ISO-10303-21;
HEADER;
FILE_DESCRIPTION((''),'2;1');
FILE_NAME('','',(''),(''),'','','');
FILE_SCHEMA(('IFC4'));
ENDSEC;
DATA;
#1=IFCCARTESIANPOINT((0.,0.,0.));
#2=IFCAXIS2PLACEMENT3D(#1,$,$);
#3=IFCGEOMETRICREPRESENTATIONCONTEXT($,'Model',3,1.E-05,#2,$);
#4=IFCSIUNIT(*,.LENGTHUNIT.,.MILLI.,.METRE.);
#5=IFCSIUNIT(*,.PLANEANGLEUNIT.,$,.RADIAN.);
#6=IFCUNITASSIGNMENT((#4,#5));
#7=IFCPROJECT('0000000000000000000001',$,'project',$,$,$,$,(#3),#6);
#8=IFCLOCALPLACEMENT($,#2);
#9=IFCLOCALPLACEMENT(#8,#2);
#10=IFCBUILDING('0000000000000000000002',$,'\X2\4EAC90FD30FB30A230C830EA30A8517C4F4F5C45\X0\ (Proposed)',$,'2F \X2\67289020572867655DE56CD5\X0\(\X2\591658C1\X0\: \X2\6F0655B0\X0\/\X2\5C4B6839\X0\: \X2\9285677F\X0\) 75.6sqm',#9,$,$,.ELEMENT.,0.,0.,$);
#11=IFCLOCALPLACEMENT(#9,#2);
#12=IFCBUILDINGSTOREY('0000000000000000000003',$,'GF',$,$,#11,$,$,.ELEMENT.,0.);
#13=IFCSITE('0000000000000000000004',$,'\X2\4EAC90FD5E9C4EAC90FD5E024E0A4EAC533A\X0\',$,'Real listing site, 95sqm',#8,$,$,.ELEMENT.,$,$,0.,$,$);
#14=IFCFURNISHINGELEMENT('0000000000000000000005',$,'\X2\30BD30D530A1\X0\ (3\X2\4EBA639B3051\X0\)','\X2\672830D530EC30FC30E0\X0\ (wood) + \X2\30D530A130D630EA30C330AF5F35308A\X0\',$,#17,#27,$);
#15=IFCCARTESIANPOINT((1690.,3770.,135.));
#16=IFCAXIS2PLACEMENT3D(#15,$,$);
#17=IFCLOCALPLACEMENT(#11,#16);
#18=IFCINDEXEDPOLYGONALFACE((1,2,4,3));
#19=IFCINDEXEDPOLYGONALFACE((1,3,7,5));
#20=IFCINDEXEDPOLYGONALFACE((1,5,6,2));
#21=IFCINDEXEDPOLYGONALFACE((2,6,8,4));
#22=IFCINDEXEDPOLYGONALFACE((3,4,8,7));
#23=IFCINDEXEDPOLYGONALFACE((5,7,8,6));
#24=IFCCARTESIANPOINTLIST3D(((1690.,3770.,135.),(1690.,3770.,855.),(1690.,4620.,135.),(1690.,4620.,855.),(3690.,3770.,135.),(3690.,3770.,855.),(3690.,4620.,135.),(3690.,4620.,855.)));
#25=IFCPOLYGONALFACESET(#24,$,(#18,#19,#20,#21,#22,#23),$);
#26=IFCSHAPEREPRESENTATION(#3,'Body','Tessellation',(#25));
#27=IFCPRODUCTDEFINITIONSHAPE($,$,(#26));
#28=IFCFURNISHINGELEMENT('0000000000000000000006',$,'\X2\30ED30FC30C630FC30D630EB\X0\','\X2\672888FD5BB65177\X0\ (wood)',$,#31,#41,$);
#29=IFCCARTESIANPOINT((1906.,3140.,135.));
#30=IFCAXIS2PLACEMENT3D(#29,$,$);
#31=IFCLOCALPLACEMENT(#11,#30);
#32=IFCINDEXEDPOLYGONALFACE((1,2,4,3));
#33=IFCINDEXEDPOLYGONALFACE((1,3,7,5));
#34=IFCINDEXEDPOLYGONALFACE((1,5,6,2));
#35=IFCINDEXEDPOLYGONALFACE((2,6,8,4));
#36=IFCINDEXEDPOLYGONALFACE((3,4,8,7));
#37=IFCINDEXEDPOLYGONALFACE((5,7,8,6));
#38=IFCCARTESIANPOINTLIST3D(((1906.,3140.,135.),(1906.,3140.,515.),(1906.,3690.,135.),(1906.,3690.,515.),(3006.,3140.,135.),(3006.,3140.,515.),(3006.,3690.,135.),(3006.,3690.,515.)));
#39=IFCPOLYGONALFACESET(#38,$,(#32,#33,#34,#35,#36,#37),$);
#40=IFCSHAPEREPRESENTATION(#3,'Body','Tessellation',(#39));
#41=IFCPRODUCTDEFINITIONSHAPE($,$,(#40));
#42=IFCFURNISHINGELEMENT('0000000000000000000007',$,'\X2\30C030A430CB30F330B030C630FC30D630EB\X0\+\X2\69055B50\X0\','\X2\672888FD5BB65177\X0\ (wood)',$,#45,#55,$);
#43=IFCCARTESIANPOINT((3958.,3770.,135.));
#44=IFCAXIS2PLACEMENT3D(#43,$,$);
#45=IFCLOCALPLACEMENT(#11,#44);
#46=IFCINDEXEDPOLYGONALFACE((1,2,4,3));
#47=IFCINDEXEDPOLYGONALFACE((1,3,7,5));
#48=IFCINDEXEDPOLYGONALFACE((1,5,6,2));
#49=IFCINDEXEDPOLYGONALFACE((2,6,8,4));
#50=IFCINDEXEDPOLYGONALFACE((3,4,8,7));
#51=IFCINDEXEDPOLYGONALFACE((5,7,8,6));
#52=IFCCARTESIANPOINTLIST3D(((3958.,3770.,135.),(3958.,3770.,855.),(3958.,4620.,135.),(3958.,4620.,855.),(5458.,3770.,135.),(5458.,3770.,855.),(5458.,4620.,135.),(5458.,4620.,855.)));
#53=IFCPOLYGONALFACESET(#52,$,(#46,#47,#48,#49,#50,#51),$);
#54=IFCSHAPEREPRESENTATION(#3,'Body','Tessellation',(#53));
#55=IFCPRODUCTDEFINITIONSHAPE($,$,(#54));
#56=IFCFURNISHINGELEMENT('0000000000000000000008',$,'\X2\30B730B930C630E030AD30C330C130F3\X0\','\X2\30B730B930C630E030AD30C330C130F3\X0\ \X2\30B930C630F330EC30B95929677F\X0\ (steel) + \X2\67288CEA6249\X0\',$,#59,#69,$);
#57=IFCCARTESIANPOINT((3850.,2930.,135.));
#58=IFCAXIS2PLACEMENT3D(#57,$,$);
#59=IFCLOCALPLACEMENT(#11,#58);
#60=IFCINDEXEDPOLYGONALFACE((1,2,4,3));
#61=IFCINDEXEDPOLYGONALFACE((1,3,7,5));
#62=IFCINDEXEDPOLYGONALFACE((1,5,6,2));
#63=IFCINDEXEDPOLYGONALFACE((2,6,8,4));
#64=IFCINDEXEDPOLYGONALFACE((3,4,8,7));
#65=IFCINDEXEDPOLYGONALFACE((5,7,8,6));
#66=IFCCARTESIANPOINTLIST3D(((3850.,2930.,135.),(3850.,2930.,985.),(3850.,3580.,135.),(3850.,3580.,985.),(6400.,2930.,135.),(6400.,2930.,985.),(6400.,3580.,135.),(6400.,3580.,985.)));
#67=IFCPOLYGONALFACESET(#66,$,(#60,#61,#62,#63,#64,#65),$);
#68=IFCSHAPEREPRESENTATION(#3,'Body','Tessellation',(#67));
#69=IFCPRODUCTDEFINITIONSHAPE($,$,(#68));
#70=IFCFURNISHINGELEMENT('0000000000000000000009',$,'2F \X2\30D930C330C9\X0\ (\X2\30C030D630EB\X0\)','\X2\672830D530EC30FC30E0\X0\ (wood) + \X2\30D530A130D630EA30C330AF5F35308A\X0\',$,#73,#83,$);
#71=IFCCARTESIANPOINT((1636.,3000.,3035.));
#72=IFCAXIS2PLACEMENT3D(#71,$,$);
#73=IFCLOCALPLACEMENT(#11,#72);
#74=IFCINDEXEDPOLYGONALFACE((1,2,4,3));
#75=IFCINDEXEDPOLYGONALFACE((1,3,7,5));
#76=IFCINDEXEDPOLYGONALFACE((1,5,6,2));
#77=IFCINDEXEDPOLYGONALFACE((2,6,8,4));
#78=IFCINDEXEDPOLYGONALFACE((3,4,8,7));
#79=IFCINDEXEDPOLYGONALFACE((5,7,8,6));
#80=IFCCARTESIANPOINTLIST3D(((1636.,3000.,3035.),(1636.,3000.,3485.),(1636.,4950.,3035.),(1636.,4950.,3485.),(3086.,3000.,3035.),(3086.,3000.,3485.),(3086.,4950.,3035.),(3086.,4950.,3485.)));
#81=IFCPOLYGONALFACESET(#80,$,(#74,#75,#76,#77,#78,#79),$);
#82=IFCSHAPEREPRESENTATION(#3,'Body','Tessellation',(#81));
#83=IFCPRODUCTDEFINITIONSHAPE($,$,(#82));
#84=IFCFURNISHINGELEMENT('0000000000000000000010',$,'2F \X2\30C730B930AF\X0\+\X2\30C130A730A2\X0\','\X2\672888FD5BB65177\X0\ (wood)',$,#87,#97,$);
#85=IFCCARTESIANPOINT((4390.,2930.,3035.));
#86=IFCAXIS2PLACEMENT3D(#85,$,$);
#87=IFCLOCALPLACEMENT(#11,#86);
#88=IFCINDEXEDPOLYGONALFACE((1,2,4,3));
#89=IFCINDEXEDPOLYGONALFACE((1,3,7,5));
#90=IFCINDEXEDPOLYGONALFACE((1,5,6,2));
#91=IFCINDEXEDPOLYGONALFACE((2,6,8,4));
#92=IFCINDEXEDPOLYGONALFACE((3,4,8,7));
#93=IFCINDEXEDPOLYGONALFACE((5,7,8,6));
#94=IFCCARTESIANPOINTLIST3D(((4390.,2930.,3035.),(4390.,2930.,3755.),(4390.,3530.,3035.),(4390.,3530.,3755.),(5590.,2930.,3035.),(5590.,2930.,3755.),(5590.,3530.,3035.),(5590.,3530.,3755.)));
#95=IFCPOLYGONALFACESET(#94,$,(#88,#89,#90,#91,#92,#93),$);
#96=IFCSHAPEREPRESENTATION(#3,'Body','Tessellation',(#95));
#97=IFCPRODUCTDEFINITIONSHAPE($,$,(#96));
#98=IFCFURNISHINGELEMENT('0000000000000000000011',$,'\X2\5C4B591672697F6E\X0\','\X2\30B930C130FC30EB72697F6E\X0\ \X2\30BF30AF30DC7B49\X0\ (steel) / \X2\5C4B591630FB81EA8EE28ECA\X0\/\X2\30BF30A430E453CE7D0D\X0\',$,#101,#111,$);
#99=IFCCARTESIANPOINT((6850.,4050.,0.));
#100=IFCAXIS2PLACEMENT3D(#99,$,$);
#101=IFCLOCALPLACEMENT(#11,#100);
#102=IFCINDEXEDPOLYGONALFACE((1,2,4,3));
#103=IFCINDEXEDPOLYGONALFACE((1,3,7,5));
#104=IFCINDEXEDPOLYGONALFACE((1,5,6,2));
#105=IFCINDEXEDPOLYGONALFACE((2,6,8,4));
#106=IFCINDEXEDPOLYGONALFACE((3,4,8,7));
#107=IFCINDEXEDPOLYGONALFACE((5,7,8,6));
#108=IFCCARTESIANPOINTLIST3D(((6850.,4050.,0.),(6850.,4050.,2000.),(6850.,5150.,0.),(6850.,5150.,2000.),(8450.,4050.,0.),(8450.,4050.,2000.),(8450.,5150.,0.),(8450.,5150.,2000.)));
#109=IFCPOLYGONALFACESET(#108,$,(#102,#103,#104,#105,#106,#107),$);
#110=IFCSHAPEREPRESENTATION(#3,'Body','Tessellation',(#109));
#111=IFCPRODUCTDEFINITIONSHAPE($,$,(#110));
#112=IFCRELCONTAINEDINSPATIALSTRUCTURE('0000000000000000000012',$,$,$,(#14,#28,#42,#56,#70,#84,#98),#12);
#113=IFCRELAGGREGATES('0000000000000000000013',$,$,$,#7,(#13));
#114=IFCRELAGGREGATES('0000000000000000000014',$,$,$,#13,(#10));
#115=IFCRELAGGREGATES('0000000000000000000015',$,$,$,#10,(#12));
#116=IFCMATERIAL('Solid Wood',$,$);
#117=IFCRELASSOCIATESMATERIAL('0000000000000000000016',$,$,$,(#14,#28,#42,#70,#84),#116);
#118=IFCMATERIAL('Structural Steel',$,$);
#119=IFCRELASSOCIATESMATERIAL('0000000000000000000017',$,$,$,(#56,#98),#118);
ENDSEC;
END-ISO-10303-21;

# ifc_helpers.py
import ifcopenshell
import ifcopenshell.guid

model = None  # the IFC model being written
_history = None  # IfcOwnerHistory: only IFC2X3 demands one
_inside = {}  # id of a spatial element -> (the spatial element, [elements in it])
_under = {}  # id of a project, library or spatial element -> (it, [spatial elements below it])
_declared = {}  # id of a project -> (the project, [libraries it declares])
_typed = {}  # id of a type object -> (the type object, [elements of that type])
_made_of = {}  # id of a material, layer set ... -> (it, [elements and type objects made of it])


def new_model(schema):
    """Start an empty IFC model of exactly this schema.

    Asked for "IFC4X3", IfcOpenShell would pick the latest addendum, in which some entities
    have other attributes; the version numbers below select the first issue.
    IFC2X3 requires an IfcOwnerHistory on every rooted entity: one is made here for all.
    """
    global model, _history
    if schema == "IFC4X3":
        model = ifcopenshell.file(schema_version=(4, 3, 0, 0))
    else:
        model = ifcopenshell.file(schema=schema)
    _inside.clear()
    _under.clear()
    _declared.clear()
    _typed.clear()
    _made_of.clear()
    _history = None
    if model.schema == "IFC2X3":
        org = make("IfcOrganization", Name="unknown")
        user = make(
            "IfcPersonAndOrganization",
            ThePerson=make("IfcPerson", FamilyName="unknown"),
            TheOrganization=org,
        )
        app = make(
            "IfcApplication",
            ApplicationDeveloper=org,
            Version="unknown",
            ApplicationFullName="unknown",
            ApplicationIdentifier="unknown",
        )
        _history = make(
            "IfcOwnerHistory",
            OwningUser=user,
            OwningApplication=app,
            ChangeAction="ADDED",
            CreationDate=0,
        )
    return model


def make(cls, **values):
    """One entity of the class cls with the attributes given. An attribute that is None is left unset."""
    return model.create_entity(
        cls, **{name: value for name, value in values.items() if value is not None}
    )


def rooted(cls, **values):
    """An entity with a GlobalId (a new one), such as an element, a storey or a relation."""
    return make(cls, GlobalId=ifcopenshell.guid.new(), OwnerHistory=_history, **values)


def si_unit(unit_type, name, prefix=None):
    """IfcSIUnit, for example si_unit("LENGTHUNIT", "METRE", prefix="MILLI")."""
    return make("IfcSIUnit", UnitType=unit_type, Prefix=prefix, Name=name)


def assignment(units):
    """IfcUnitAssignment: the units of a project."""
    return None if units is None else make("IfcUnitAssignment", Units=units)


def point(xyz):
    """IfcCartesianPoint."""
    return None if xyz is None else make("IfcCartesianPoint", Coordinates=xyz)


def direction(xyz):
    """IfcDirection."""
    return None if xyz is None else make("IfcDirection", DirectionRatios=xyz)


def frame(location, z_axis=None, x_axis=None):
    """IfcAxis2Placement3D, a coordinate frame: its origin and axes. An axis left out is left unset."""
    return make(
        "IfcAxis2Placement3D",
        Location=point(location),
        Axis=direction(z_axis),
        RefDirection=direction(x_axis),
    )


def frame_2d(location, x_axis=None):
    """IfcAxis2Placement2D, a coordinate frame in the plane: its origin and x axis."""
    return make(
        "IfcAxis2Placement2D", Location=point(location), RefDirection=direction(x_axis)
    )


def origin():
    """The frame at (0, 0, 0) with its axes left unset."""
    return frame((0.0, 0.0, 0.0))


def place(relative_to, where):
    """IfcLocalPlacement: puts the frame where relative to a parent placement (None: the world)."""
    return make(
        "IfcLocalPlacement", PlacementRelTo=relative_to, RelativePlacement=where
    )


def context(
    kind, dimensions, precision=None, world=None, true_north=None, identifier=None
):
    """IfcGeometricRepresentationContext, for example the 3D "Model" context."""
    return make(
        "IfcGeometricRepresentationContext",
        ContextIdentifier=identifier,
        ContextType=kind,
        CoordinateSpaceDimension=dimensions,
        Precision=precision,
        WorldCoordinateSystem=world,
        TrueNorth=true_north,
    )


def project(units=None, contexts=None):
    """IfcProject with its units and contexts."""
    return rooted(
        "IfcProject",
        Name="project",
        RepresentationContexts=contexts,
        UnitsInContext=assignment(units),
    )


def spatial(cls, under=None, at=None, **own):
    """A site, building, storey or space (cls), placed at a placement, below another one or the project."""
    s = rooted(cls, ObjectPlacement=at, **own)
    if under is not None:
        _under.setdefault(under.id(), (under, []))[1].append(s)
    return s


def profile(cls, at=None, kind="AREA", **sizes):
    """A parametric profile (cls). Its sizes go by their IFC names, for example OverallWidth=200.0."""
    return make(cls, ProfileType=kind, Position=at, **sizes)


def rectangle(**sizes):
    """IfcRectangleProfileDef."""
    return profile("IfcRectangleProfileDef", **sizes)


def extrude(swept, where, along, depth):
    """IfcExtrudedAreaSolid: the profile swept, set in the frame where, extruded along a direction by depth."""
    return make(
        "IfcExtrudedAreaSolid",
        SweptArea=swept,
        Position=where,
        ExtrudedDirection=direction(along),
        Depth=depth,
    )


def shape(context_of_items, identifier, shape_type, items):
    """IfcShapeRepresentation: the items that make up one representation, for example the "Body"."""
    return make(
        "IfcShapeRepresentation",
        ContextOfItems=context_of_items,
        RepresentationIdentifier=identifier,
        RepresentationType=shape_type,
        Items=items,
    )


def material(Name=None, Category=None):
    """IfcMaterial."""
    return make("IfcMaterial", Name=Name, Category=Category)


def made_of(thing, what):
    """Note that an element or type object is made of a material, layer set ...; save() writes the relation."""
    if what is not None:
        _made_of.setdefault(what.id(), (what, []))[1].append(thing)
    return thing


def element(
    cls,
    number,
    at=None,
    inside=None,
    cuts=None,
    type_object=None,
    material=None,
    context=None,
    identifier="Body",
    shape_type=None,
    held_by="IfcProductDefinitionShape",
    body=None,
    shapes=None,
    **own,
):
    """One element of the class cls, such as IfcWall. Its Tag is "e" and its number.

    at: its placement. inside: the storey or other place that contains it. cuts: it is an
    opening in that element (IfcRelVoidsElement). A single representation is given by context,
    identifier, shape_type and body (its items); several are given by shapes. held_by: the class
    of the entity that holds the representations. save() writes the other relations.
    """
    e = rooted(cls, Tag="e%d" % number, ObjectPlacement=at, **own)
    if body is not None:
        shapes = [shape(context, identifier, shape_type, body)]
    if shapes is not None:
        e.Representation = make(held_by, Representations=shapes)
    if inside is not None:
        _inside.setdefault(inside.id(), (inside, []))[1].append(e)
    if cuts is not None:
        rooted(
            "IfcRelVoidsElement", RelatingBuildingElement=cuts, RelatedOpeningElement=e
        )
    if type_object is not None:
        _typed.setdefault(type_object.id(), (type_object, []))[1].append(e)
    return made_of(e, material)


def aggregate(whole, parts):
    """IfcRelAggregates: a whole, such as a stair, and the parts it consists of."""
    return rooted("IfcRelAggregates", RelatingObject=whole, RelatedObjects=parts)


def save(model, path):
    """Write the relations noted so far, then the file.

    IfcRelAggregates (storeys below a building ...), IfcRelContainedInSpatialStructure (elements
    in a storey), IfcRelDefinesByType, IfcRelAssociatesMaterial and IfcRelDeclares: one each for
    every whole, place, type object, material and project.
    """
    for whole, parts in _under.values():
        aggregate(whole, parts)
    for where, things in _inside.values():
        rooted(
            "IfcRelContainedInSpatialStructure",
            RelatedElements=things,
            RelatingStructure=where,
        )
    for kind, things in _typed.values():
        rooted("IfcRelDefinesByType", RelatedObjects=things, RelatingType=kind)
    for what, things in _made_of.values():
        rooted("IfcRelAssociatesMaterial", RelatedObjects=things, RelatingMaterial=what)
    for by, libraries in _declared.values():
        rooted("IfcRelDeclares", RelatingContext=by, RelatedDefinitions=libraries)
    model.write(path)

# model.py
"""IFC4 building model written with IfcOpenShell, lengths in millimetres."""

from ifc_helpers import new_model, si_unit, frame, frame_2d, origin, place, context, project, spatial, rectangle, extrude, material, element, save


model = new_model("IFC4")

# Units and contexts
model_context = context("Model", 3, precision=1e-05, world=origin())
ifc_project = project(units=[si_unit("LENGTHUNIT", "METRE", prefix="MILLI"), si_unit("PLANEANGLEUNIT", "RADIAN")], contexts=[model_context])

# Site, building, storey
site_placement = place(None, origin())
site = spatial("IfcSite", under=ifc_project, at=site_placement, Name="京都府京都市上京区", ObjectType="Real listing site, 95sqm", CompositionType="ELEMENT", RefElevation=0.0)
building_placement = place(site_placement, origin())
building = spatial("IfcBuilding", under=site, at=building_placement, Name="京都・アトリエ兼住居 (Proposed)", ObjectType="2F 木造在来工法(外壁: 漆喰/屋根: 銅板) 75.6sqm", CompositionType="ELEMENT", ElevationOfRefHeight=0.0, ElevationOfTerrain=0.0)
storey_placement = place(building_placement, origin())
storey = spatial("IfcBuildingStorey", under=building, at=storey_placement, Name="GF", CompositionType="ELEMENT", Elevation=0.0)

# Shared definitions
ifc_material_1 = material(Name="Solid Wood")

# Shared definitions
ifc_material_2 = material(Name="Structural Steel")

# Furnishing elements
furnishing_1_placement = place(storey_placement, frame((1690.0, 3770.0, 135.0)))
element("IfcFurnishingElement", 1, at=furnishing_1_placement, inside=storey, material=ifc_material_1, Name="ソファ (3人掛け)", Description="木フレーム (wood) + ファブリック張り", context=model_context, shape_type="SweptSolid", body=[
    extrude(rectangle(XDim=2000.0, YDim=850.0, at=frame_2d((1000.0, 425.0))), frame((1690.0, 3770.0, 135.0)), (0.0, 0.0, 1.0), 720.0),
])
furnishing_2_placement = place(storey_placement, frame((1906.0, 3140.0, 135.0)))
element("IfcFurnishingElement", 2, at=furnishing_2_placement, inside=storey, material=ifc_material_1, Name="ローテーブル", Description="木製家具 (wood)", context=model_context, shape_type="SweptSolid", body=[
    extrude(rectangle(XDim=1100.0, YDim=550.0, at=frame_2d((550.0, 275.0))), frame((1906.0, 3140.0, 135.0)), (0.0, 0.0, 1.0), 380.0),
])
furnishing_3_placement = place(storey_placement, frame((3958.0, 3770.0, 135.0)))
element("IfcFurnishingElement", 3, at=furnishing_3_placement, inside=storey, material=ifc_material_1, Name="ダイニングテーブル+椅子", Description="木製家具 (wood)", context=model_context, shape_type="SweptSolid", body=[
    extrude(rectangle(XDim=1500.0, YDim=850.0, at=frame_2d((750.0, 425.0))), frame((3958.0, 3770.0, 135.0)), (0.0, 0.0, 1.0), 720.0),
])
furnishing_4_placement = place(storey_placement, frame((3850.0, 2930.0, 135.0)))
element("IfcFurnishingElement", 4, at=furnishing_4_placement, inside=storey, material=ifc_material_2, Name="システムキッチン", Description="システムキッチン ステンレス天板 (steel) + 木質扉", context=model_context, shape_type="SweptSolid", body=[
    extrude(rectangle(XDim=2550.0, YDim=650.0, at=frame_2d((1275.0, 325.0))), frame((3850.0, 2930.0, 135.0)), (0.0, 0.0, 1.0), 850.0),
])
furnishing_5_placement = place(storey_placement, frame((1636.0, 3000.0, 3035.0)))
element("IfcFurnishingElement", 5, at=furnishing_5_placement, inside=storey, material=ifc_material_1, Name="2F ベッド (ダブル)", Description="木フレーム (wood) + ファブリック張り", context=model_context, shape_type="SweptSolid", body=[
    extrude(rectangle(XDim=1450.0, YDim=1950.0, at=frame_2d((725.0, 975.0))), frame((1636.0, 3000.0, 3035.0)), (0.0, 0.0, 1.0), 450.0),
])
furnishing_6_placement = place(storey_placement, frame((4390.0, 2930.0, 3035.0)))
element("IfcFurnishingElement", 6, at=furnishing_6_placement, inside=storey, material=ifc_material_1, Name="2F デスク+チェア", Description="木製家具 (wood)", context=model_context, shape_type="SweptSolid", body=[
    extrude(rectangle(XDim=1200.0, YDim=600.0, at=frame_2d((600.0, 300.0))), frame((4390.0, 2930.0, 3035.0)), (0.0, 0.0, 1.0), 720.0),
])
furnishing_7_placement = place(storey_placement, frame((6850.0, 4050.0, 0.0)))
element("IfcFurnishingElement", 7, at=furnishing_7_placement, inside=storey, material=ifc_material_2, Name="屋外物置", Description="スチール物置 タクボ等 (steel) / 屋外・自転車/タイヤ収納", context=model_context, shape_type="SweptSolid", body=[
    extrude(rectangle(XDim=1600.0, YDim=1100.0, at=frame_2d((800.0, 550.0))), frame((6850.0, 4050.0, 0.0)), (0.0, 0.0, 1.0), 2000.0),
])

save(model, "model.ifc")
